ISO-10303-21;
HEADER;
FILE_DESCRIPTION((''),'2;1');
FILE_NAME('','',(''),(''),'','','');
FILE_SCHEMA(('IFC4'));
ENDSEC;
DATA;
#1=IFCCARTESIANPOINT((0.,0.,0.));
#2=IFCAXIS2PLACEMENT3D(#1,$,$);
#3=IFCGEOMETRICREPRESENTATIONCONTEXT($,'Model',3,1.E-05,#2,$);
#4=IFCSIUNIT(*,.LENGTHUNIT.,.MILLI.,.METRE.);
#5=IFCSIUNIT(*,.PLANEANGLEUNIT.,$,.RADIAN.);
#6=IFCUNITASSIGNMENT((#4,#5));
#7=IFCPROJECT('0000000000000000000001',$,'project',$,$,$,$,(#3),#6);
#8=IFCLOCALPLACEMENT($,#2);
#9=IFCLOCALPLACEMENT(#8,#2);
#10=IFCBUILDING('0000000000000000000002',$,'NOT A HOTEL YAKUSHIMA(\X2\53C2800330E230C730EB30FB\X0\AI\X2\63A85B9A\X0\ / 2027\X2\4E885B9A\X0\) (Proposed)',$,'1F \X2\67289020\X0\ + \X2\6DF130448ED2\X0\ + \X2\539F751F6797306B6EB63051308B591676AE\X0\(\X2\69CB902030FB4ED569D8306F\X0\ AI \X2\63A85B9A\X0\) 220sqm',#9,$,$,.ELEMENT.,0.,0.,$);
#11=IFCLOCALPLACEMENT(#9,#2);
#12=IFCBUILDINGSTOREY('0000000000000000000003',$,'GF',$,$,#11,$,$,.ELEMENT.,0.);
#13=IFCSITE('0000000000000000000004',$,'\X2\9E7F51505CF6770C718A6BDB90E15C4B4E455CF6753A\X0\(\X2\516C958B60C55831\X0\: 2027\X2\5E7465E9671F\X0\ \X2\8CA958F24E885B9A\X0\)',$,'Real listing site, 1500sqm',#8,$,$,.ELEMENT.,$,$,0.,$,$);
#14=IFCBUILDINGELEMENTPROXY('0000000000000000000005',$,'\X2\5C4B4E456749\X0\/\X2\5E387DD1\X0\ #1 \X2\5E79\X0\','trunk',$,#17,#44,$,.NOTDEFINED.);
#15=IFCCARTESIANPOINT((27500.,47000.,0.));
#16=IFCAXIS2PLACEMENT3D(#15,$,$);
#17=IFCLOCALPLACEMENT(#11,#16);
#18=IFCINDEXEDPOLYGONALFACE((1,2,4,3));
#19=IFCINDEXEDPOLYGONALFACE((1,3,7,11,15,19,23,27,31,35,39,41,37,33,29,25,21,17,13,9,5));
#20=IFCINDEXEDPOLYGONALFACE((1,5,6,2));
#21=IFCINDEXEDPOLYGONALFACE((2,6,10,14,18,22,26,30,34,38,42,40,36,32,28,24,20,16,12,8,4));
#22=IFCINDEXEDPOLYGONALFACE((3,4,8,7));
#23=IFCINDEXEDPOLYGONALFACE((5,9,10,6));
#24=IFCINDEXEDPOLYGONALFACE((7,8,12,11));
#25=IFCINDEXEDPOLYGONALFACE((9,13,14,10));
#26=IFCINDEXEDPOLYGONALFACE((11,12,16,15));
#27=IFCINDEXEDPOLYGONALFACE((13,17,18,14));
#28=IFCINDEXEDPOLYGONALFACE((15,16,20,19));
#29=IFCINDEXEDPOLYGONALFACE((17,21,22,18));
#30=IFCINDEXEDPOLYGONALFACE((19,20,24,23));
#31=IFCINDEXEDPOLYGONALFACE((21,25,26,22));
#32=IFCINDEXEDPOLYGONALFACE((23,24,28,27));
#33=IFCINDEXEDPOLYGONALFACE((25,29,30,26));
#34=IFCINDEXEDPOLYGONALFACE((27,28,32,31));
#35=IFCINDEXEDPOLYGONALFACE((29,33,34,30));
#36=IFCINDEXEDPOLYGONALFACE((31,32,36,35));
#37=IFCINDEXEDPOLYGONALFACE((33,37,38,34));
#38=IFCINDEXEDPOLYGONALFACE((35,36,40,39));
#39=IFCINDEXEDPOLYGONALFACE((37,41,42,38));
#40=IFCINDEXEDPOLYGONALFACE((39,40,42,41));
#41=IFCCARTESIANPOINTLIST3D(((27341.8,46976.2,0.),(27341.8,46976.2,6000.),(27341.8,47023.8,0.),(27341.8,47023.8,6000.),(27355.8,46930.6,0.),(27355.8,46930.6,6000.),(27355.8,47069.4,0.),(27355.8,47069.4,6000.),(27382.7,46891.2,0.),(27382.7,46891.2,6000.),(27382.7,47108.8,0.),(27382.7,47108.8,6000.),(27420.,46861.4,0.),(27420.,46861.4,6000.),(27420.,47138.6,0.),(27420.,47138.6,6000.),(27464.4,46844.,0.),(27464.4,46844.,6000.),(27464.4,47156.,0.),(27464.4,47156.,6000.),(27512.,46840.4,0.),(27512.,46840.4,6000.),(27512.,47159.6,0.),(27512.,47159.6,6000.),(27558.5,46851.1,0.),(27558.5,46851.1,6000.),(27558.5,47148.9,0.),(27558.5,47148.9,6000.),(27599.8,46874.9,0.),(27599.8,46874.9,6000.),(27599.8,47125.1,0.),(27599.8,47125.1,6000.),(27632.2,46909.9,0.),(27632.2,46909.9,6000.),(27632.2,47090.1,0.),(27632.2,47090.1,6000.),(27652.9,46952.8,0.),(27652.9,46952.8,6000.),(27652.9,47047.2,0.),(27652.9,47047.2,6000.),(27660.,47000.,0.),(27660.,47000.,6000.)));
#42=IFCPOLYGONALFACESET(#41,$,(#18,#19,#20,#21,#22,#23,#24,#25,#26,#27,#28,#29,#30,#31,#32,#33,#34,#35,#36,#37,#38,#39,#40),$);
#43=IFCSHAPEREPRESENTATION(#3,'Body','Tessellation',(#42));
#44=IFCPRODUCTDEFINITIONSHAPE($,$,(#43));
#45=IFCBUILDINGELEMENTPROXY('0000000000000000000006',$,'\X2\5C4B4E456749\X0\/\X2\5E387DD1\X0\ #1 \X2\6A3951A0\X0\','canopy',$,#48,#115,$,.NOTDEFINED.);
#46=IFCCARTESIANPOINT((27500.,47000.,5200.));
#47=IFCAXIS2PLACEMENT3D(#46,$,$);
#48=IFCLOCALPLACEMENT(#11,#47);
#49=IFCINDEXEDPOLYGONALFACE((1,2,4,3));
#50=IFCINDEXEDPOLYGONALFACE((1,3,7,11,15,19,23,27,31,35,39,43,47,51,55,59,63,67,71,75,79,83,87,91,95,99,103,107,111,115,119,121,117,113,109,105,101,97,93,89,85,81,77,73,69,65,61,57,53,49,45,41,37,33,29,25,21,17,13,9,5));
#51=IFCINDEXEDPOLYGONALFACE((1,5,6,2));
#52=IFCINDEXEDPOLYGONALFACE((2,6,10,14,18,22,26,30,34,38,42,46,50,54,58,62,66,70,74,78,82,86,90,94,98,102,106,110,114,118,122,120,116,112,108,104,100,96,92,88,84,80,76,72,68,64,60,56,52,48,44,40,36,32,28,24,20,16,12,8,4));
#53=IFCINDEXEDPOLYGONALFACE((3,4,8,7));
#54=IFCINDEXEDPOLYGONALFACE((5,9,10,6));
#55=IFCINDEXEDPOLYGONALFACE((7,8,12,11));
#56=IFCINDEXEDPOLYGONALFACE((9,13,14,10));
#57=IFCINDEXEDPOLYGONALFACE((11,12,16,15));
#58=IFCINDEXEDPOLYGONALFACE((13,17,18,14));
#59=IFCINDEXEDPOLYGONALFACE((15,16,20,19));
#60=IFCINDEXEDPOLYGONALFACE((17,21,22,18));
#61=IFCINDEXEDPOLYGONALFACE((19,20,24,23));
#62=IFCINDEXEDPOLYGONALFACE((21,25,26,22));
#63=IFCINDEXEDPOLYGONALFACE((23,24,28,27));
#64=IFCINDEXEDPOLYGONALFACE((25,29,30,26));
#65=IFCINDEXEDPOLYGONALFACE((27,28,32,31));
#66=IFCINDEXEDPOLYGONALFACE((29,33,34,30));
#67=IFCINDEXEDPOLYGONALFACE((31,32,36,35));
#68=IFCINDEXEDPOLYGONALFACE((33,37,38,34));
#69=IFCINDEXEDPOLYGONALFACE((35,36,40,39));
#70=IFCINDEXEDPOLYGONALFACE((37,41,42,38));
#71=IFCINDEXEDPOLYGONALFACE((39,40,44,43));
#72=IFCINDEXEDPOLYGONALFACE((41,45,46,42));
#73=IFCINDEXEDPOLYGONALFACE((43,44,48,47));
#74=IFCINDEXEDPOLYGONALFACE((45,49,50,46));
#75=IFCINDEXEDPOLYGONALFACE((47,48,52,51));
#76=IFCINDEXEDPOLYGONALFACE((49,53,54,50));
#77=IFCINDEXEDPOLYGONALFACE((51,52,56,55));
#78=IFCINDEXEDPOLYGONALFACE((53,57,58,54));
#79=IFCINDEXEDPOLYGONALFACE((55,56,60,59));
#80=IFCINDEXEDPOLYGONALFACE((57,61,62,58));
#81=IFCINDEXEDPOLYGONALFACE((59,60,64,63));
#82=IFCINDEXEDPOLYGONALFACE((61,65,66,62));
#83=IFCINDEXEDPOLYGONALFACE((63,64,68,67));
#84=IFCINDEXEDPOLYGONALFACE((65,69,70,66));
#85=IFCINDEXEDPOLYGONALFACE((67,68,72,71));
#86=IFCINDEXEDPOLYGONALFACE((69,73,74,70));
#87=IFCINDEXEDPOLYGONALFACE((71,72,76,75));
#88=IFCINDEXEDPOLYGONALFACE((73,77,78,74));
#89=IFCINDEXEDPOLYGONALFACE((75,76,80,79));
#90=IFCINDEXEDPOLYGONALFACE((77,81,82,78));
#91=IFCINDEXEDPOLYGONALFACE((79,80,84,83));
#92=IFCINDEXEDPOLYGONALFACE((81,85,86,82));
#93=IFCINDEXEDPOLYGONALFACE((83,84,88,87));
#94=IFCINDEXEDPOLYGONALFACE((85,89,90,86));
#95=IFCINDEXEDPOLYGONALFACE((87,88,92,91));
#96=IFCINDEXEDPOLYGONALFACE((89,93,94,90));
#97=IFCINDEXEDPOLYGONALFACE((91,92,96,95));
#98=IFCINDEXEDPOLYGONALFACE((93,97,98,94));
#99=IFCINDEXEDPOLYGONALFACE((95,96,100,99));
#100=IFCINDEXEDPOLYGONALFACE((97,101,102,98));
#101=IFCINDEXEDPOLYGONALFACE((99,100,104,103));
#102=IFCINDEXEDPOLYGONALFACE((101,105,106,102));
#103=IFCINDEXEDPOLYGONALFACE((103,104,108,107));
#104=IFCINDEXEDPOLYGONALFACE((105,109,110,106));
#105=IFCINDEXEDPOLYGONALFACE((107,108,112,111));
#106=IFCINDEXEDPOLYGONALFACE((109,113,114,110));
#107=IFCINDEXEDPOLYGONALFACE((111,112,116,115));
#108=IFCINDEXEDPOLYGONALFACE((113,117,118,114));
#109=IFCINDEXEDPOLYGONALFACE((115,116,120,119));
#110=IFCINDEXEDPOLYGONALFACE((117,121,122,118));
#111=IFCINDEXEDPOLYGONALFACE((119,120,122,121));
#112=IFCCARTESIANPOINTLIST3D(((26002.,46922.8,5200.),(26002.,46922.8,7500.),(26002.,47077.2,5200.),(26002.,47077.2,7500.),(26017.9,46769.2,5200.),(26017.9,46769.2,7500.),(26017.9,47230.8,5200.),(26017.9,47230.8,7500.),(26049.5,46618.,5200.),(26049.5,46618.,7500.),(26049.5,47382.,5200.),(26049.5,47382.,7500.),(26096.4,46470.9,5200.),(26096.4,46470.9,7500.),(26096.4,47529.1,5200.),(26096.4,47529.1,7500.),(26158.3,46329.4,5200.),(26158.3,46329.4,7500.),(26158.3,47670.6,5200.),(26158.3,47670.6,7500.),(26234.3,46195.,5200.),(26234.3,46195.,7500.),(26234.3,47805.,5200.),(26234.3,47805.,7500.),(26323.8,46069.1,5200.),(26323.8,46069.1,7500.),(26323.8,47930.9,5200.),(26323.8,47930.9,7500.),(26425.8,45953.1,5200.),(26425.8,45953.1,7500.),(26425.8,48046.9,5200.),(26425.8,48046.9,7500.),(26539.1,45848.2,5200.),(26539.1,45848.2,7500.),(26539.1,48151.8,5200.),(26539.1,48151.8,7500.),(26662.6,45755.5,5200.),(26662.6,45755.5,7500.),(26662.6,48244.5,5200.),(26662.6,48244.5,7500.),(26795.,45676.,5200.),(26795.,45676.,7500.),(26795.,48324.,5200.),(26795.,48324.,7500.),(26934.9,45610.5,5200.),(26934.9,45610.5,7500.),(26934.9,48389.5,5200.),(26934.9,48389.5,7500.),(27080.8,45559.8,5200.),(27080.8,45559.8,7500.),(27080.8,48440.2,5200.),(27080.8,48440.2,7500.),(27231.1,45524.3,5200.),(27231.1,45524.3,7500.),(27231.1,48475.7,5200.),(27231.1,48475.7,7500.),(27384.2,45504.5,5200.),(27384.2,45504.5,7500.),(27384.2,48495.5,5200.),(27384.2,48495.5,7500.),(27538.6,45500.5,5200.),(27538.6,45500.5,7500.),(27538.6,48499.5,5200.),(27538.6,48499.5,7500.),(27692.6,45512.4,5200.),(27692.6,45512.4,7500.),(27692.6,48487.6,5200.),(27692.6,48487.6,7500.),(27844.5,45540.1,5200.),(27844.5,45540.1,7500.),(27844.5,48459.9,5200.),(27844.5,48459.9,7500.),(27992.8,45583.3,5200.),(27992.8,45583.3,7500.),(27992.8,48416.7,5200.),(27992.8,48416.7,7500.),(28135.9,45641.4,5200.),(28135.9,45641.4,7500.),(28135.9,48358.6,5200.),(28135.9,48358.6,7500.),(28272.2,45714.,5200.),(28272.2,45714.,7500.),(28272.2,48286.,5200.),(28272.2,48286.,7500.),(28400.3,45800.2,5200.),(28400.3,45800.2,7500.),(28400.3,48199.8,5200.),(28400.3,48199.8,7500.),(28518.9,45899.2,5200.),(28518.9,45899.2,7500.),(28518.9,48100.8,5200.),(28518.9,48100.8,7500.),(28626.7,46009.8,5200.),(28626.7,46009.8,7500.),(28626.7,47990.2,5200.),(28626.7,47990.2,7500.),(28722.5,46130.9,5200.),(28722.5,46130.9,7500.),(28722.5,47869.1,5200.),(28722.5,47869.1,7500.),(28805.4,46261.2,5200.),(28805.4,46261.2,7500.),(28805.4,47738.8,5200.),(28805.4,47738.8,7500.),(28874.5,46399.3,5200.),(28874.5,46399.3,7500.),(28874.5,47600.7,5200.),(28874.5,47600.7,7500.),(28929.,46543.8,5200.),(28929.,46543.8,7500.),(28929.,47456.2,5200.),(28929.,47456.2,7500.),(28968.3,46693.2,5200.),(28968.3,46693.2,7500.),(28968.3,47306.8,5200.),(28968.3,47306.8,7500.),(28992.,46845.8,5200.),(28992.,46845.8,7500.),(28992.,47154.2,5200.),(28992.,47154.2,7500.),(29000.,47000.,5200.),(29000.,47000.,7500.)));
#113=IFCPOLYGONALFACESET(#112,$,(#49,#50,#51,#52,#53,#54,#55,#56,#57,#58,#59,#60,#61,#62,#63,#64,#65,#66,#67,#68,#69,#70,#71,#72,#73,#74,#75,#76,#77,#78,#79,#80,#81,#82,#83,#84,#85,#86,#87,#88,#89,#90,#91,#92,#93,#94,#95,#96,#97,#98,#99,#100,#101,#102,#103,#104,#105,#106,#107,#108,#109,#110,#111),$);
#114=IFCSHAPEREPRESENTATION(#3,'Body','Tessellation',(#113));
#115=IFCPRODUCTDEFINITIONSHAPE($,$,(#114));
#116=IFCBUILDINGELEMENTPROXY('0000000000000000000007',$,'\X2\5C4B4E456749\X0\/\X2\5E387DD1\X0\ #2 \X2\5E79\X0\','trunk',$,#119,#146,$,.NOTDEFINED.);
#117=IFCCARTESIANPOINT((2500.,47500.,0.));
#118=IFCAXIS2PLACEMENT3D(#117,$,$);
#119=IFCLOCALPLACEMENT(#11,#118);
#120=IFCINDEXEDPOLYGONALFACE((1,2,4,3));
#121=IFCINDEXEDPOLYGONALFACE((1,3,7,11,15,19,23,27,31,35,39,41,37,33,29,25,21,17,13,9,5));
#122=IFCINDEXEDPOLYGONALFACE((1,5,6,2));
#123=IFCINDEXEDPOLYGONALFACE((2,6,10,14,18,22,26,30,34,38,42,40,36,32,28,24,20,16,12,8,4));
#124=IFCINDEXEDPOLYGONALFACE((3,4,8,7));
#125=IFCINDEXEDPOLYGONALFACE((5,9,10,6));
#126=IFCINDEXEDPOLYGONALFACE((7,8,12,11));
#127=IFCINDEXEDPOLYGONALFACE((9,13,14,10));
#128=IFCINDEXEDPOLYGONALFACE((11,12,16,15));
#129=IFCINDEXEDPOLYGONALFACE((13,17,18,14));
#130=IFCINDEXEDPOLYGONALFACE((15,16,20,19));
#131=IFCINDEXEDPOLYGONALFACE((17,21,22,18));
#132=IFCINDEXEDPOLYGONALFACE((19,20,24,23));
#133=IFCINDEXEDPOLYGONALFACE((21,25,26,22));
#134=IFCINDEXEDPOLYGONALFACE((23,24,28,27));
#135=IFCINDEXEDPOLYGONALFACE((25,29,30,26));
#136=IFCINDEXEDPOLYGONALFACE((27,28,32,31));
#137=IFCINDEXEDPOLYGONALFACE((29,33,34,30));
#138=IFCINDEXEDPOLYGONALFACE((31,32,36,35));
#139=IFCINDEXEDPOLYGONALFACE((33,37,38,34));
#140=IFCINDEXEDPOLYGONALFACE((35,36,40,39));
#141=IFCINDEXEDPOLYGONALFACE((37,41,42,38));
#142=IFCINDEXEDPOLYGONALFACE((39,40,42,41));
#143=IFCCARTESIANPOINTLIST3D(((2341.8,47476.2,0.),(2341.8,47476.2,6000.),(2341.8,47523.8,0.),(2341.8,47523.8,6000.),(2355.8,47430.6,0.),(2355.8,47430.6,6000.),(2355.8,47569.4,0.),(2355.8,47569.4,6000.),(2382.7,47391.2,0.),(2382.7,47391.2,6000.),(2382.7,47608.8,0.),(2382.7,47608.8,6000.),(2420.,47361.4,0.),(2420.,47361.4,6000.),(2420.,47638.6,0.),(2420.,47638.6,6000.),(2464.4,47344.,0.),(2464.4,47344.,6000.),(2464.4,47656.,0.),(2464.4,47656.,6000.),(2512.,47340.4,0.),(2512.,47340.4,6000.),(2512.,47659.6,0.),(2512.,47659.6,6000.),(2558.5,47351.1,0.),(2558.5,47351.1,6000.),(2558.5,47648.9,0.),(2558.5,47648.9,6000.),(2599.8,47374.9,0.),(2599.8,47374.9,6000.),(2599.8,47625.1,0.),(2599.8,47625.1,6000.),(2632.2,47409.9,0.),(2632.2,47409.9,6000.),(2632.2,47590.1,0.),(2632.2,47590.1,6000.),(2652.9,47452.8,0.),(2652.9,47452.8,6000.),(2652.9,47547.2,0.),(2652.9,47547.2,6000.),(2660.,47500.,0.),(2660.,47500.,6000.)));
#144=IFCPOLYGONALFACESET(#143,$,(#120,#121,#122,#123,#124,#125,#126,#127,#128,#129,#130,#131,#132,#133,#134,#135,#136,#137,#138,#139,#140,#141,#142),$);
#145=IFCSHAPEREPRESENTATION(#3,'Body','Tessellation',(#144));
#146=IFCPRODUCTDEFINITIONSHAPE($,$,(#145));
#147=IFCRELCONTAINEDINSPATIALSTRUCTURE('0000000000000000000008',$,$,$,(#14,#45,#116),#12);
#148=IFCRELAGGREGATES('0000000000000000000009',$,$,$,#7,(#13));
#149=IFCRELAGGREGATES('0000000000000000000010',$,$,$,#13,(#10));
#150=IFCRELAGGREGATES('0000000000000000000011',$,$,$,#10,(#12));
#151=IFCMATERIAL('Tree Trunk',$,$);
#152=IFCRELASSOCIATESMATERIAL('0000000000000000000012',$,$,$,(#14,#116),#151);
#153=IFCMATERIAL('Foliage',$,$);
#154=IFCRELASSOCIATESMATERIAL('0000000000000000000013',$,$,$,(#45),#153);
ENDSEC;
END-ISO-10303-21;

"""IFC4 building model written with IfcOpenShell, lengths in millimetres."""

from ifc_helpers import new_model, si_unit, frame, origin, origin_2d, place, context, project, spatial, circle, extrude, material, element, save


model = new_model("IFC4")

# Units and contexts
model_context = context("Model", 3, precision=1e-05, world=origin())
ifc_project = project(units=[si_unit("LENGTHUNIT", "METRE", prefix="MILLI"), si_unit("PLANEANGLEUNIT", "RADIAN")], contexts=[model_context])

# Site, building, storey
site_placement = place(None, origin())
site = spatial("IfcSite", under=ifc_project, at=site_placement, Name="鹿児島県熊毛郡屋久島町(公開情報: 2027年早期 販売予定)", ObjectType="Real listing site, 1500sqm", CompositionType="ELEMENT", RefElevation=0.0)
building_placement = place(site_placement, origin())
building = spatial("IfcBuilding", under=site, at=building_placement, Name="NOT A HOTEL YAKUSHIMA(参考モデル・AI推定 / 2027予定) (Proposed)", ObjectType="1F 木造 + 深い軒 + 原生林に溶ける外皮(構造・仕様は AI 推定) 220sqm", CompositionType="ELEMENT", ElevationOfRefHeight=0.0, ElevationOfTerrain=0.0)
storey_placement = place(building_placement, origin())
storey = spatial("IfcBuildingStorey", under=building, at=storey_placement, Name="GF", CompositionType="ELEMENT", Elevation=0.0)

# Building element proxies
ifc_material_1 = material(Name="Tree Trunk")
proxy_1_placement = place(storey_placement, frame((27500.0, 47000.0, 0.0)))
element("IfcBuildingElementProxy", 1, at=proxy_1_placement, inside=storey, material=ifc_material_1, Name="屋久杉/常緑 #1 幹", Description="trunk", PredefinedType="NOTDEFINED", context=model_context, shape_type="SweptSolid", body=[
    extrude(circle(Radius=160.0, at=origin_2d()), frame((27500.0, 47000.0, 0.0)), (0.0, 0.0, 1.0), 6000.0),
])
ifc_material_2 = material(Name="Foliage")
proxy_2_placement = place(storey_placement, frame((27500.0, 47000.0, 5200.0)))
element("IfcBuildingElementProxy", 2, at=proxy_2_placement, inside=storey, material=ifc_material_2, Name="屋久杉/常緑 #1 樹冠", Description="canopy", PredefinedType="NOTDEFINED", context=model_context, shape_type="SweptSolid", body=[
    extrude(circle(Radius=1500.0, at=origin_2d()), frame((27500.0, 47000.0, 5200.0)), (0.0, 0.0, 1.0), 2300.0),
])
proxy_3_placement = place(storey_placement, frame((2500.0, 47500.0, 0.0)))
element("IfcBuildingElementProxy", 3, at=proxy_3_placement, inside=storey, material=ifc_material_1, Name="屋久杉/常緑 #2 幹", Description="trunk", PredefinedType="NOTDEFINED", context=model_context, shape_type="SweptSolid", body=[
    extrude(circle(Radius=160.0, at=origin_2d()), frame((2500.0, 47500.0, 0.0)), (0.0, 0.0, 1.0), 6000.0),
])

save(model, "model.ifc")
